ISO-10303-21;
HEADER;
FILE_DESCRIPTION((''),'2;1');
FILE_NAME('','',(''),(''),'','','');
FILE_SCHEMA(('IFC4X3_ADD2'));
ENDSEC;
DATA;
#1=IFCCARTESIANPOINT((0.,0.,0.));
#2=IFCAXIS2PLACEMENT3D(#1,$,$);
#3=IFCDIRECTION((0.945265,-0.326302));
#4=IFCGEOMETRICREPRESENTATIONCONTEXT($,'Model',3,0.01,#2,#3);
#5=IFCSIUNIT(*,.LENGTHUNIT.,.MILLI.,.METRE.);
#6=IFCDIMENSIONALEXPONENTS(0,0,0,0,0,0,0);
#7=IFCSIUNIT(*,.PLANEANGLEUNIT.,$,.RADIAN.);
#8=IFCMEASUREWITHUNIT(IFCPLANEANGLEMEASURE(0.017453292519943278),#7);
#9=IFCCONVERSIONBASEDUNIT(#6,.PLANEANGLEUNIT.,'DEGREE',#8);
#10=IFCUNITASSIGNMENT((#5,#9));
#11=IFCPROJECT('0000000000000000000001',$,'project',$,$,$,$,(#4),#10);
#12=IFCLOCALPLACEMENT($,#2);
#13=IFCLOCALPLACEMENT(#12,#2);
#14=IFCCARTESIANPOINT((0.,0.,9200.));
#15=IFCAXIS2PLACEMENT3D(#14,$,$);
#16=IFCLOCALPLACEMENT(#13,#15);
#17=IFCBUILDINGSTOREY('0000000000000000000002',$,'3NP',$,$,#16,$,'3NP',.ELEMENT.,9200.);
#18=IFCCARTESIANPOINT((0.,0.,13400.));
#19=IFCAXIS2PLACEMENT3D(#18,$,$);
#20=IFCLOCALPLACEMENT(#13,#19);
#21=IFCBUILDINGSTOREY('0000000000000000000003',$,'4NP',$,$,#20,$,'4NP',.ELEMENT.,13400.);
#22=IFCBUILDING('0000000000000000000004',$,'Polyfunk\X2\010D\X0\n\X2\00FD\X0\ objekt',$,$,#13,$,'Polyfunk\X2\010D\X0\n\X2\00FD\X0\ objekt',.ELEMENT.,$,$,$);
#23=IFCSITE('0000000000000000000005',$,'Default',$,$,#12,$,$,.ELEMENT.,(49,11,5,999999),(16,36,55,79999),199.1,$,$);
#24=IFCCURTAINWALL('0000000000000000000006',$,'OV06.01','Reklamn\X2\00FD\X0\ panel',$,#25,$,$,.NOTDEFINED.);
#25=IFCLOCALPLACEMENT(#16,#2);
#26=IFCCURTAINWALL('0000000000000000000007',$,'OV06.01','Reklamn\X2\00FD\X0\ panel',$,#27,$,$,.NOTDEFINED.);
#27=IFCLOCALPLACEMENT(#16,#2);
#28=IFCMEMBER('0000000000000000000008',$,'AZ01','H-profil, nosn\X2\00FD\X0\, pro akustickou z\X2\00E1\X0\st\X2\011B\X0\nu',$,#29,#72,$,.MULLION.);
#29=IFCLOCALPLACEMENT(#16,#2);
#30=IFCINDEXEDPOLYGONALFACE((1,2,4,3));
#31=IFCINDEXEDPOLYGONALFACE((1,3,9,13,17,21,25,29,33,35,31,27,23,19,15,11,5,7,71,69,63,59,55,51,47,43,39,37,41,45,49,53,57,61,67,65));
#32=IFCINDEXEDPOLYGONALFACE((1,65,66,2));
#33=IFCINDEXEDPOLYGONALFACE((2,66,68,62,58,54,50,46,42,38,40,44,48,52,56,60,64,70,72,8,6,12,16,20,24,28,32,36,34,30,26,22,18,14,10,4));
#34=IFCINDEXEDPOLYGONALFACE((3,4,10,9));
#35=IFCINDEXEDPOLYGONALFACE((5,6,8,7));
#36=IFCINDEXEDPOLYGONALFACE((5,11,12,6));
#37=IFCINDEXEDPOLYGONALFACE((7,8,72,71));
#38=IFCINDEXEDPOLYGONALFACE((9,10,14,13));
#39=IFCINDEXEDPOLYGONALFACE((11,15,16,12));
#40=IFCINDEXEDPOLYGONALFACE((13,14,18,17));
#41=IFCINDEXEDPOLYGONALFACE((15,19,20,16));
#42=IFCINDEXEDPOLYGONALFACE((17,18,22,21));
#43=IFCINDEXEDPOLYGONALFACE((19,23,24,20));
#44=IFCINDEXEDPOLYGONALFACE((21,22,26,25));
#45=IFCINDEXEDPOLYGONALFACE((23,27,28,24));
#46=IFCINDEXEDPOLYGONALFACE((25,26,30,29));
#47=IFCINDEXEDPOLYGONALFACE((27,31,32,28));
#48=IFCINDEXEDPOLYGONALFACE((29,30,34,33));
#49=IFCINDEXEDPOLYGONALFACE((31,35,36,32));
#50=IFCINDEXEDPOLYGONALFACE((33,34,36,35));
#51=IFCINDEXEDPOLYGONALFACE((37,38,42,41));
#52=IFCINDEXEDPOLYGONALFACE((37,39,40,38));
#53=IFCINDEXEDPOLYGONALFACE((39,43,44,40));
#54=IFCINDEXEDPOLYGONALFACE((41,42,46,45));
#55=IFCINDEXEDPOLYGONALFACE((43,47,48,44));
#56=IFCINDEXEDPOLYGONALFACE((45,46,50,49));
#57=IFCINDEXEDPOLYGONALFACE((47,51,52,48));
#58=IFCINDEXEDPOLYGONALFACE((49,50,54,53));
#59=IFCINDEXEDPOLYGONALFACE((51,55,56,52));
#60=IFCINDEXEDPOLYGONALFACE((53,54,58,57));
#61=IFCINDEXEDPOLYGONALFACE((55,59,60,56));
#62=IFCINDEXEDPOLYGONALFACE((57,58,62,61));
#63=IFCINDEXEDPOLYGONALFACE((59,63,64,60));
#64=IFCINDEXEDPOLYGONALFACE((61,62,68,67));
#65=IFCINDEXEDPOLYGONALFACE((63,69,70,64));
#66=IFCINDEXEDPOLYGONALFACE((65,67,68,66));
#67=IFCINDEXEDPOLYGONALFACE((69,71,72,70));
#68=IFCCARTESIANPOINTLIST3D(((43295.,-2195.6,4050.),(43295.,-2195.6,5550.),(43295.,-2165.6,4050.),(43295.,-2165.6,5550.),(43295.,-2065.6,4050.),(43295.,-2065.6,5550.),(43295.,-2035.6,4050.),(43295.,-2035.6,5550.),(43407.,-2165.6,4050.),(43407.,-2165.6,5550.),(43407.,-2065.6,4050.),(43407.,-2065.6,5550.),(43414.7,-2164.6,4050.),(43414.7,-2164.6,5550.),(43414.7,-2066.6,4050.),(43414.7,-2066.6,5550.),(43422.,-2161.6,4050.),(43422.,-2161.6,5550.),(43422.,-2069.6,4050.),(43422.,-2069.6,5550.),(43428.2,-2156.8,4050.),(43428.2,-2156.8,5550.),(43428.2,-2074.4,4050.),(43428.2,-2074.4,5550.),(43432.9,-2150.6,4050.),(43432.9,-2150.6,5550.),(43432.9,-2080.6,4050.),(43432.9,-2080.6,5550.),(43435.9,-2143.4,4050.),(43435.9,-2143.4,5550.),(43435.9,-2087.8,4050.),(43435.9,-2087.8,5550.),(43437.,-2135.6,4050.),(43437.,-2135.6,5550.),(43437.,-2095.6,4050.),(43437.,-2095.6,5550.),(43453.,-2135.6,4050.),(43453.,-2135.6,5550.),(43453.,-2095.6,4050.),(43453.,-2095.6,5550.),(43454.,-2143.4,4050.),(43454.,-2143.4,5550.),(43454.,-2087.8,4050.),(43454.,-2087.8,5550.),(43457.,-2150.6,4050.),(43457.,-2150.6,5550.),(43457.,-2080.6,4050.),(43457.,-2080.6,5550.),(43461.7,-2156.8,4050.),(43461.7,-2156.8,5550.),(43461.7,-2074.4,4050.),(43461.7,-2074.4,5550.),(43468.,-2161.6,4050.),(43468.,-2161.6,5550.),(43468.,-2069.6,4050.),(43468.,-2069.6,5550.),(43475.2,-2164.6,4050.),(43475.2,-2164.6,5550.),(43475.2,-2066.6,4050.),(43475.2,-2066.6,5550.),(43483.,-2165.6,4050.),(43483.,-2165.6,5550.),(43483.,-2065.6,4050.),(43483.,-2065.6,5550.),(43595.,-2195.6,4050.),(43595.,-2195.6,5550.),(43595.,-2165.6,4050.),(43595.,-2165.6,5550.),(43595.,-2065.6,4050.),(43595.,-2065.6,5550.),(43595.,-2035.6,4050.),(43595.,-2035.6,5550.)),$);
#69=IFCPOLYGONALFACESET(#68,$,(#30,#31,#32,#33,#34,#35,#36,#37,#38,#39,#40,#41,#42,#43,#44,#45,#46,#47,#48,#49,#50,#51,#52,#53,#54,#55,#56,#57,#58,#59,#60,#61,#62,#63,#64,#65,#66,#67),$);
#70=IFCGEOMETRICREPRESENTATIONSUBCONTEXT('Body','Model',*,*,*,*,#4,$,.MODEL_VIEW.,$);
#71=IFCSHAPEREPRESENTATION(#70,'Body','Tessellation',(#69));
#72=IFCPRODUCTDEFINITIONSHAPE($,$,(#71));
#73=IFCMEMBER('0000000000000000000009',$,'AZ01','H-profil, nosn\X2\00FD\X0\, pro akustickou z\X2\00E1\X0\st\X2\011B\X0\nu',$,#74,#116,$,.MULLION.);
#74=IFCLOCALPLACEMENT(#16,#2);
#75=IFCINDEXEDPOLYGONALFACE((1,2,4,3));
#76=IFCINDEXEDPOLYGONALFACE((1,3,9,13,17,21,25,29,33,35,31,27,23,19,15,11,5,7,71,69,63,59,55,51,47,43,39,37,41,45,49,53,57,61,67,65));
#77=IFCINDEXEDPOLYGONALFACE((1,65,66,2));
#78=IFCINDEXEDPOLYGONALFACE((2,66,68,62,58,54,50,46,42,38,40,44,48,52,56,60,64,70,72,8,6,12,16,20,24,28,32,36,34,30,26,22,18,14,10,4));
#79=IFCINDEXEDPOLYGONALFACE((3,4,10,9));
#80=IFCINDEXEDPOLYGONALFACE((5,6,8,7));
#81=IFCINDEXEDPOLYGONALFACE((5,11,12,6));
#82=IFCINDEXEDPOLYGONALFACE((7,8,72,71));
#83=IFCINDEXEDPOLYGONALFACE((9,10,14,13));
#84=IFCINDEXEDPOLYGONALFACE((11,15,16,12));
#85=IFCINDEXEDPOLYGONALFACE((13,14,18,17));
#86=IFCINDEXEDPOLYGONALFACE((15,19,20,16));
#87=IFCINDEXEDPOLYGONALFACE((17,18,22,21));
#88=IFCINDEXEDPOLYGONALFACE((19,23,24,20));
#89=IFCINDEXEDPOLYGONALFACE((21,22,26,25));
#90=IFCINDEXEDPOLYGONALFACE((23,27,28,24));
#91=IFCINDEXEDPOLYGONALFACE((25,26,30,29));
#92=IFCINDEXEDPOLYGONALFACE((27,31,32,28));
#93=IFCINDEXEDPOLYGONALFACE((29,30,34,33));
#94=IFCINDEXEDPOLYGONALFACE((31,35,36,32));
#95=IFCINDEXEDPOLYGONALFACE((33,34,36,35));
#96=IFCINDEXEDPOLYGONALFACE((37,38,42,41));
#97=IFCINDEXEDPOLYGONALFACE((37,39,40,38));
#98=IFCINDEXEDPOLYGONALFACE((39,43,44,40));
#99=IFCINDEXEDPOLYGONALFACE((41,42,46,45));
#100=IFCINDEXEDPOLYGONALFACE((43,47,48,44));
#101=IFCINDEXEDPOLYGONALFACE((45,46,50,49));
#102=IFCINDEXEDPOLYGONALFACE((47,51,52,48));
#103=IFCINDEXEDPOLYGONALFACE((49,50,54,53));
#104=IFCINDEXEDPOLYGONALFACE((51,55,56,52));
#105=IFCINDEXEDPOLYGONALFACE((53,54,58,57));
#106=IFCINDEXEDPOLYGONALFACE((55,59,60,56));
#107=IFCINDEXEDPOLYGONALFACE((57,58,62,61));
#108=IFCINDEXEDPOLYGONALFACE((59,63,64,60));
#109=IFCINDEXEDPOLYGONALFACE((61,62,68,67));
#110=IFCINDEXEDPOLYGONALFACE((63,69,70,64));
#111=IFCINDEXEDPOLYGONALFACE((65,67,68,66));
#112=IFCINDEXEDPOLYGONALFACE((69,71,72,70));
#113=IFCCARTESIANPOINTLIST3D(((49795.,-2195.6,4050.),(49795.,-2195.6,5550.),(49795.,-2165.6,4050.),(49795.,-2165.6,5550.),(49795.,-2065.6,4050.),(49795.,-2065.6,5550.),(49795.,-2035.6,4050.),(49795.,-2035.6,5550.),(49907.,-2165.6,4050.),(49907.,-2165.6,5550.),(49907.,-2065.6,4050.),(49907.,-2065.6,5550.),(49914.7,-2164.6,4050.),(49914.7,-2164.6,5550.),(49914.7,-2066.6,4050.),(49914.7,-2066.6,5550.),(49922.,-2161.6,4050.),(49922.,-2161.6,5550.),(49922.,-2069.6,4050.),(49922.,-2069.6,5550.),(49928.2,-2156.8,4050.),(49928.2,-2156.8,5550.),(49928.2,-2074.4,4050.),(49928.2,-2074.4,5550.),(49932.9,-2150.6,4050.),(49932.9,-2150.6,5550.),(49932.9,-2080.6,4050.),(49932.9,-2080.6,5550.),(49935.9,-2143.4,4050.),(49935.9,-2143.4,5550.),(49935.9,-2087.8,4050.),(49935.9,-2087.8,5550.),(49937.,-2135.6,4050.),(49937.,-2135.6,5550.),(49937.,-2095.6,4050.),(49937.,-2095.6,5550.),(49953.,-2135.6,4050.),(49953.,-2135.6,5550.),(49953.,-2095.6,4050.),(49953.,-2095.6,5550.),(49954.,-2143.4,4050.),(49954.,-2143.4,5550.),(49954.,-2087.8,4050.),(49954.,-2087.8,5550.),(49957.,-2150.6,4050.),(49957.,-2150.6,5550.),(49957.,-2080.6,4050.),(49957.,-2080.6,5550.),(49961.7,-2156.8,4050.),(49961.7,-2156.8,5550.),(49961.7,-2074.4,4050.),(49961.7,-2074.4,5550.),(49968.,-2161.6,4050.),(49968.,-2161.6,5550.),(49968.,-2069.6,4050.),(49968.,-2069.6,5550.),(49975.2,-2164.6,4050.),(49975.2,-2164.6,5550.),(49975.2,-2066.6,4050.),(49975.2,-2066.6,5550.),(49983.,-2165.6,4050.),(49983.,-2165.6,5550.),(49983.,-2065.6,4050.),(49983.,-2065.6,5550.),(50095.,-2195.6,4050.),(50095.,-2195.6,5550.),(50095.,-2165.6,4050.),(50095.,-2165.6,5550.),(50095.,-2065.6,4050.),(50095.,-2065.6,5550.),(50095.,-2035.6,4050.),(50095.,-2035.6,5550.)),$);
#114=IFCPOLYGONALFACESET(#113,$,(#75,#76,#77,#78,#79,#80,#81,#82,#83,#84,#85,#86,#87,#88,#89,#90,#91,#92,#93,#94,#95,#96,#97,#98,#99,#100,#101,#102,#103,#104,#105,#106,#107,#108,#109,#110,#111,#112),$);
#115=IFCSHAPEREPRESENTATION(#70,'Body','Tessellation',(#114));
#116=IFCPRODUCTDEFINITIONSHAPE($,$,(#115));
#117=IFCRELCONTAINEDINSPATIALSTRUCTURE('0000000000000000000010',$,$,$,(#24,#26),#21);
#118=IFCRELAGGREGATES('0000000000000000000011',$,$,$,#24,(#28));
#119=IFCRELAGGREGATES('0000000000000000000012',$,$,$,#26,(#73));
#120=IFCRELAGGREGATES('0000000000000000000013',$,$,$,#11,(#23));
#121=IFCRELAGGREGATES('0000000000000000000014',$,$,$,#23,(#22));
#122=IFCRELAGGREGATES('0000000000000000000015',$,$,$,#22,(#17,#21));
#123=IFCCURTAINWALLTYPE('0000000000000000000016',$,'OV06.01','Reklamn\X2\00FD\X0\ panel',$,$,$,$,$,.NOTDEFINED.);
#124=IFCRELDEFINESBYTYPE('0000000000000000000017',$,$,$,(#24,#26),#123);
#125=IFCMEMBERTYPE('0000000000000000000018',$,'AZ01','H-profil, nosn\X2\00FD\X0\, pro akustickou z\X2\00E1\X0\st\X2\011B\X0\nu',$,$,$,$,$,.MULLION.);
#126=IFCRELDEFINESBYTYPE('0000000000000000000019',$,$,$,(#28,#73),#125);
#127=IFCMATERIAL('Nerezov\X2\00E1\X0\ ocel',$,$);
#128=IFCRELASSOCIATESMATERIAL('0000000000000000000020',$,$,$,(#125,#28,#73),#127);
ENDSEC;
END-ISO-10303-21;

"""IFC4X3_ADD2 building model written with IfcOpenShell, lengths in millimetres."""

from ifc_helpers import new_model, entity, si_unit, converted_unit, direction, frame, frame_2d, origin, place, context, subcontext, project, spatial, polyline, circle_curve, parameter, trimmed, segment, composite_curve, outline, extrude, source, transform, mapped, material, material_profile, profile_set, profile_usage, type_object, element, aggregate, save


model = new_model("IFC4X3_ADD2")

# Units and contexts
model_context = context("Model", 3, precision=0.01, world=origin(), true_north=direction((0.945265, -0.326302)))
body_context = subcontext(model_context, "Body", "Model", "MODEL_VIEW")
ifc_project = project(units=[si_unit("LENGTHUNIT", "METRE", prefix="MILLI"), converted_unit("PLANEANGLEUNIT", "DEGREE", entity("IfcPlaneAngleMeasure", 0.017453292519943278), si_unit("PLANEANGLEUNIT", "RADIAN"), dimensions=[0, 0, 0, 0, 0, 0, 0])], contexts=[model_context])

# Site, building, storey
site_placement = place(None, origin())
site = spatial("IfcSite", under=ifc_project, at=site_placement, Name="Default", CompositionType="ELEMENT", RefLatitude=(49, 11, 5, 999999), RefLongitude=(16, 36, 55, 79999), RefElevation=199.1)
building_placement = place(site_placement, origin())
building = spatial("IfcBuilding", under=site, at=building_placement, Name="Polyfunkčný objekt", LongName="Polyfunkčný objekt", CompositionType="ELEMENT")
storey_1_placement = place(building_placement, frame((0.0, 0.0, 9200.0)))
storey_1 = spatial("IfcBuildingStorey", under=building, at=storey_1_placement, Name="3NP", LongName="3NP", CompositionType="ELEMENT", Elevation=9200.0)

# Shared definitions
storey_2_placement = place(building_placement, frame((0.0, 0.0, 13400.0)))
storey_2 = spatial("IfcBuildingStorey", under=building, at=storey_2_placement, Name="4NP", LongName="4NP", CompositionType="ELEMENT", Elevation=13400.0)

# Shared definitions
ifc_material_1 = material(Name="Nerezová ocel")
ifc_material_profile_1 = material_profile(ifc_material_1, outline(composite_curve([segment(polyline([(50.0, -150.0), (80.0, -150.0)]), True, "CONTINUOUS"), segment(polyline([(80.0, -150.0), (80.0, 150.0)]), True, "CONTINUOUS"), segment(polyline([(80.0, 150.0), (50.0, 150.0)]), True, "CONTINUOUS"), segment(polyline([(50.0, 150.0), (50.0, 38.0)]), True, "CONTINUOUS"), segment(trimmed(circle_curve(frame_2d((20.0, 38.0), x_axis=(0.0, 1.0)), 30.0), [parameter(180.0)], [parameter(270.0)], True, "PARAMETER"), False, "CONTINUOUS"), segment(polyline([(20.0, 8.0), (-20.0, 8.0)]), True, "CONTINUOUS"), segment(trimmed(circle_curve(frame_2d((-20.0, 38.0), x_axis=(0.0, 1.0)), 30.0), [parameter(90.0)], [parameter(180.0)], True, "PARAMETER"), False, "CONTINUOUS"), segment(polyline([(-50.0, 38.0), (-50.0, 150.0)]), True, "CONTINUOUS"), segment(polyline([(-50.0, 150.0), (-80.0, 150.0)]), True, "CONTINUOUS"), segment(polyline([(-80.0, 150.0), (-80.0, -150.0)]), True, "CONTINUOUS"), segment(polyline([(-80.0, -150.0), (-50.0, -150.0)]), True, "CONTINUOUS"), segment(polyline([(-50.0, -150.0), (-50.0, -38.0)]), True, "CONTINUOUS"), segment(trimmed(circle_curve(frame_2d((-20.0, -38.0), x_axis=(0.0, 1.0)), 30.0), [parameter(0.0)], [parameter(90.0)], True, "PARAMETER"), False, "CONTINUOUS"), segment(polyline([(-20.0, -8.0), (20.0, -8.0)]), True, "CONTINUOUS"), segment(trimmed(circle_curve(frame_2d((20.0, -38.0), x_axis=(0.0, 1.0)), 30.0), [parameter(270.0)], [parameter(0.0)], True, "PARAMETER"), False, "CONTINUOUS"), segment(polyline([(50.0, -38.0), (50.0, -150.0)]), True, "CONTINUOUS")], self_intersect=False)), Name="Profil zástena")
ifc_profile_set_1 = profile_set([ifc_material_profile_1], Name="Profil zástena")
ifc_profile_usage_1 = profile_usage(ifc_profile_set_1)
member_type_1 = type_object("IfcMemberType", Name="AZ01", Description="H-profil, nosný, pro akustickou zástěnu", PredefinedType="MULLION", material=ifc_profile_set_1)

# Curtain walls
curtain_wall_type_1 = type_object("IfcCurtainWallType", Name="OV06.01", Description="Reklamný panel", PredefinedType="NOTDEFINED")
curtain_wall_1_placement = place(storey_2_placement, frame((0.0, 0.0, -13400.0)))
curtain_wall_1 = element("IfcCurtainWall", 1, at=curtain_wall_1_placement, inside=storey_2, type_object=curtain_wall_type_1, Name="OV06.01", Description="Reklamný panel", PredefinedType="NOTDEFINED")
curtain_wall_2_placement = place(storey_2_placement, frame((0.0, 0.0, -13400.0)))
curtain_wall_2 = element("IfcCurtainWall", 2, at=curtain_wall_2_placement, inside=storey_2, type_object=curtain_wall_type_1, Name="OV06.01", Description="Reklamný panel", PredefinedType="NOTDEFINED")

# Members
shared_shape_1 = source(origin(), body_context, "Body", "SweptSolid", [
    extrude(outline(composite_curve([segment(polyline([(50.0, -150.0), (80.0, -150.0)]), True, "CONTINUOUS"), segment(polyline([(80.0, -150.0), (80.0, 150.0)]), True, "CONTINUOUS"), segment(polyline([(80.0, 150.0), (50.0, 150.0)]), True, "CONTINUOUS"), segment(polyline([(50.0, 150.0), (50.0, 38.0)]), True, "CONTINUOUS"), segment(trimmed(circle_curve(frame_2d((20.0, 38.0), x_axis=(0.0, 1.0)), 30.0), [parameter(180.0)], [parameter(270.0)], True, "PARAMETER"), False, "CONTINUOUS"), segment(polyline([(20.0, 8.0), (-20.0, 8.0)]), True, "CONTINUOUS"), segment(trimmed(circle_curve(frame_2d((-20.0, 38.0), x_axis=(0.0, 1.0)), 30.0), [parameter(90.0)], [parameter(180.0)], True, "PARAMETER"), False, "CONTINUOUS"), segment(polyline([(-50.0, 38.0), (-50.0, 150.0)]), True, "CONTINUOUS"), segment(polyline([(-50.0, 150.0), (-80.0, 150.0)]), True, "CONTINUOUS"), segment(polyline([(-80.0, 150.0), (-80.0, -150.0)]), True, "CONTINUOUS"), segment(polyline([(-80.0, -150.0), (-50.0, -150.0)]), True, "CONTINUOUS"), segment(polyline([(-50.0, -150.0), (-50.0, -38.0)]), True, "CONTINUOUS"), segment(trimmed(circle_curve(frame_2d((-20.0, -38.0), x_axis=(0.0, 1.0)), 30.0), [parameter(0.0)], [parameter(90.0)], True, "PARAMETER"), False, "CONTINUOUS"), segment(polyline([(-20.0, -8.0), (20.0, -8.0)]), True, "CONTINUOUS"), segment(trimmed(circle_curve(frame_2d((20.0, -38.0), x_axis=(0.0, 1.0)), 30.0), [parameter(270.0)], [parameter(0.0)], True, "PARAMETER"), False, "CONTINUOUS"), segment(polyline([(50.0, -38.0), (50.0, -150.0)]), True, "CONTINUOUS")], self_intersect=False)), frame((-150.0, 0.0, -1500.0), z_axis=(0.0, 0.0, 1.0), x_axis=(0.0, 1.0, 0.0)), (0.0, 0.0, 1.0), 1500.0),
])
member_1_placement = place(curtain_wall_1_placement, frame((43295.0, -2115.6, 14750.0), z_axis=(0.0, 0.0, 1.0), x_axis=(-1.0, 0.0, 0.0)))
member_1 = element("IfcMember", 3, at=member_1_placement, type_object=member_type_1, material=ifc_profile_usage_1, Name="AZ01", Description="H-profil, nosný, pro akustickou zástěnu", PredefinedType="MULLION", context=body_context, shape_type="MappedRepresentation", body=[
    mapped(shared_shape_1, transform((0.0, 0.0, 0.0), scale=1.0)),
])
member_2_placement = place(curtain_wall_2_placement, frame((49795.0, -2115.6, 14750.0), z_axis=(0.0, 0.0, 1.0), x_axis=(-1.0, 0.0, 0.0)))
member_2 = element("IfcMember", 4, at=member_2_placement, type_object=member_type_1, material=ifc_profile_usage_1, Name="AZ01", Description="H-profil, nosný, pro akustickou zástěnu", PredefinedType="MULLION", context=body_context, shape_type="MappedRepresentation", body=[
    mapped(shared_shape_1, transform((0.0, 0.0, 0.0), scale=1.0)),
])

aggregate(curtain_wall_1, [member_1])
aggregate(curtain_wall_2, [member_2])

save(model, "model.ifc")
